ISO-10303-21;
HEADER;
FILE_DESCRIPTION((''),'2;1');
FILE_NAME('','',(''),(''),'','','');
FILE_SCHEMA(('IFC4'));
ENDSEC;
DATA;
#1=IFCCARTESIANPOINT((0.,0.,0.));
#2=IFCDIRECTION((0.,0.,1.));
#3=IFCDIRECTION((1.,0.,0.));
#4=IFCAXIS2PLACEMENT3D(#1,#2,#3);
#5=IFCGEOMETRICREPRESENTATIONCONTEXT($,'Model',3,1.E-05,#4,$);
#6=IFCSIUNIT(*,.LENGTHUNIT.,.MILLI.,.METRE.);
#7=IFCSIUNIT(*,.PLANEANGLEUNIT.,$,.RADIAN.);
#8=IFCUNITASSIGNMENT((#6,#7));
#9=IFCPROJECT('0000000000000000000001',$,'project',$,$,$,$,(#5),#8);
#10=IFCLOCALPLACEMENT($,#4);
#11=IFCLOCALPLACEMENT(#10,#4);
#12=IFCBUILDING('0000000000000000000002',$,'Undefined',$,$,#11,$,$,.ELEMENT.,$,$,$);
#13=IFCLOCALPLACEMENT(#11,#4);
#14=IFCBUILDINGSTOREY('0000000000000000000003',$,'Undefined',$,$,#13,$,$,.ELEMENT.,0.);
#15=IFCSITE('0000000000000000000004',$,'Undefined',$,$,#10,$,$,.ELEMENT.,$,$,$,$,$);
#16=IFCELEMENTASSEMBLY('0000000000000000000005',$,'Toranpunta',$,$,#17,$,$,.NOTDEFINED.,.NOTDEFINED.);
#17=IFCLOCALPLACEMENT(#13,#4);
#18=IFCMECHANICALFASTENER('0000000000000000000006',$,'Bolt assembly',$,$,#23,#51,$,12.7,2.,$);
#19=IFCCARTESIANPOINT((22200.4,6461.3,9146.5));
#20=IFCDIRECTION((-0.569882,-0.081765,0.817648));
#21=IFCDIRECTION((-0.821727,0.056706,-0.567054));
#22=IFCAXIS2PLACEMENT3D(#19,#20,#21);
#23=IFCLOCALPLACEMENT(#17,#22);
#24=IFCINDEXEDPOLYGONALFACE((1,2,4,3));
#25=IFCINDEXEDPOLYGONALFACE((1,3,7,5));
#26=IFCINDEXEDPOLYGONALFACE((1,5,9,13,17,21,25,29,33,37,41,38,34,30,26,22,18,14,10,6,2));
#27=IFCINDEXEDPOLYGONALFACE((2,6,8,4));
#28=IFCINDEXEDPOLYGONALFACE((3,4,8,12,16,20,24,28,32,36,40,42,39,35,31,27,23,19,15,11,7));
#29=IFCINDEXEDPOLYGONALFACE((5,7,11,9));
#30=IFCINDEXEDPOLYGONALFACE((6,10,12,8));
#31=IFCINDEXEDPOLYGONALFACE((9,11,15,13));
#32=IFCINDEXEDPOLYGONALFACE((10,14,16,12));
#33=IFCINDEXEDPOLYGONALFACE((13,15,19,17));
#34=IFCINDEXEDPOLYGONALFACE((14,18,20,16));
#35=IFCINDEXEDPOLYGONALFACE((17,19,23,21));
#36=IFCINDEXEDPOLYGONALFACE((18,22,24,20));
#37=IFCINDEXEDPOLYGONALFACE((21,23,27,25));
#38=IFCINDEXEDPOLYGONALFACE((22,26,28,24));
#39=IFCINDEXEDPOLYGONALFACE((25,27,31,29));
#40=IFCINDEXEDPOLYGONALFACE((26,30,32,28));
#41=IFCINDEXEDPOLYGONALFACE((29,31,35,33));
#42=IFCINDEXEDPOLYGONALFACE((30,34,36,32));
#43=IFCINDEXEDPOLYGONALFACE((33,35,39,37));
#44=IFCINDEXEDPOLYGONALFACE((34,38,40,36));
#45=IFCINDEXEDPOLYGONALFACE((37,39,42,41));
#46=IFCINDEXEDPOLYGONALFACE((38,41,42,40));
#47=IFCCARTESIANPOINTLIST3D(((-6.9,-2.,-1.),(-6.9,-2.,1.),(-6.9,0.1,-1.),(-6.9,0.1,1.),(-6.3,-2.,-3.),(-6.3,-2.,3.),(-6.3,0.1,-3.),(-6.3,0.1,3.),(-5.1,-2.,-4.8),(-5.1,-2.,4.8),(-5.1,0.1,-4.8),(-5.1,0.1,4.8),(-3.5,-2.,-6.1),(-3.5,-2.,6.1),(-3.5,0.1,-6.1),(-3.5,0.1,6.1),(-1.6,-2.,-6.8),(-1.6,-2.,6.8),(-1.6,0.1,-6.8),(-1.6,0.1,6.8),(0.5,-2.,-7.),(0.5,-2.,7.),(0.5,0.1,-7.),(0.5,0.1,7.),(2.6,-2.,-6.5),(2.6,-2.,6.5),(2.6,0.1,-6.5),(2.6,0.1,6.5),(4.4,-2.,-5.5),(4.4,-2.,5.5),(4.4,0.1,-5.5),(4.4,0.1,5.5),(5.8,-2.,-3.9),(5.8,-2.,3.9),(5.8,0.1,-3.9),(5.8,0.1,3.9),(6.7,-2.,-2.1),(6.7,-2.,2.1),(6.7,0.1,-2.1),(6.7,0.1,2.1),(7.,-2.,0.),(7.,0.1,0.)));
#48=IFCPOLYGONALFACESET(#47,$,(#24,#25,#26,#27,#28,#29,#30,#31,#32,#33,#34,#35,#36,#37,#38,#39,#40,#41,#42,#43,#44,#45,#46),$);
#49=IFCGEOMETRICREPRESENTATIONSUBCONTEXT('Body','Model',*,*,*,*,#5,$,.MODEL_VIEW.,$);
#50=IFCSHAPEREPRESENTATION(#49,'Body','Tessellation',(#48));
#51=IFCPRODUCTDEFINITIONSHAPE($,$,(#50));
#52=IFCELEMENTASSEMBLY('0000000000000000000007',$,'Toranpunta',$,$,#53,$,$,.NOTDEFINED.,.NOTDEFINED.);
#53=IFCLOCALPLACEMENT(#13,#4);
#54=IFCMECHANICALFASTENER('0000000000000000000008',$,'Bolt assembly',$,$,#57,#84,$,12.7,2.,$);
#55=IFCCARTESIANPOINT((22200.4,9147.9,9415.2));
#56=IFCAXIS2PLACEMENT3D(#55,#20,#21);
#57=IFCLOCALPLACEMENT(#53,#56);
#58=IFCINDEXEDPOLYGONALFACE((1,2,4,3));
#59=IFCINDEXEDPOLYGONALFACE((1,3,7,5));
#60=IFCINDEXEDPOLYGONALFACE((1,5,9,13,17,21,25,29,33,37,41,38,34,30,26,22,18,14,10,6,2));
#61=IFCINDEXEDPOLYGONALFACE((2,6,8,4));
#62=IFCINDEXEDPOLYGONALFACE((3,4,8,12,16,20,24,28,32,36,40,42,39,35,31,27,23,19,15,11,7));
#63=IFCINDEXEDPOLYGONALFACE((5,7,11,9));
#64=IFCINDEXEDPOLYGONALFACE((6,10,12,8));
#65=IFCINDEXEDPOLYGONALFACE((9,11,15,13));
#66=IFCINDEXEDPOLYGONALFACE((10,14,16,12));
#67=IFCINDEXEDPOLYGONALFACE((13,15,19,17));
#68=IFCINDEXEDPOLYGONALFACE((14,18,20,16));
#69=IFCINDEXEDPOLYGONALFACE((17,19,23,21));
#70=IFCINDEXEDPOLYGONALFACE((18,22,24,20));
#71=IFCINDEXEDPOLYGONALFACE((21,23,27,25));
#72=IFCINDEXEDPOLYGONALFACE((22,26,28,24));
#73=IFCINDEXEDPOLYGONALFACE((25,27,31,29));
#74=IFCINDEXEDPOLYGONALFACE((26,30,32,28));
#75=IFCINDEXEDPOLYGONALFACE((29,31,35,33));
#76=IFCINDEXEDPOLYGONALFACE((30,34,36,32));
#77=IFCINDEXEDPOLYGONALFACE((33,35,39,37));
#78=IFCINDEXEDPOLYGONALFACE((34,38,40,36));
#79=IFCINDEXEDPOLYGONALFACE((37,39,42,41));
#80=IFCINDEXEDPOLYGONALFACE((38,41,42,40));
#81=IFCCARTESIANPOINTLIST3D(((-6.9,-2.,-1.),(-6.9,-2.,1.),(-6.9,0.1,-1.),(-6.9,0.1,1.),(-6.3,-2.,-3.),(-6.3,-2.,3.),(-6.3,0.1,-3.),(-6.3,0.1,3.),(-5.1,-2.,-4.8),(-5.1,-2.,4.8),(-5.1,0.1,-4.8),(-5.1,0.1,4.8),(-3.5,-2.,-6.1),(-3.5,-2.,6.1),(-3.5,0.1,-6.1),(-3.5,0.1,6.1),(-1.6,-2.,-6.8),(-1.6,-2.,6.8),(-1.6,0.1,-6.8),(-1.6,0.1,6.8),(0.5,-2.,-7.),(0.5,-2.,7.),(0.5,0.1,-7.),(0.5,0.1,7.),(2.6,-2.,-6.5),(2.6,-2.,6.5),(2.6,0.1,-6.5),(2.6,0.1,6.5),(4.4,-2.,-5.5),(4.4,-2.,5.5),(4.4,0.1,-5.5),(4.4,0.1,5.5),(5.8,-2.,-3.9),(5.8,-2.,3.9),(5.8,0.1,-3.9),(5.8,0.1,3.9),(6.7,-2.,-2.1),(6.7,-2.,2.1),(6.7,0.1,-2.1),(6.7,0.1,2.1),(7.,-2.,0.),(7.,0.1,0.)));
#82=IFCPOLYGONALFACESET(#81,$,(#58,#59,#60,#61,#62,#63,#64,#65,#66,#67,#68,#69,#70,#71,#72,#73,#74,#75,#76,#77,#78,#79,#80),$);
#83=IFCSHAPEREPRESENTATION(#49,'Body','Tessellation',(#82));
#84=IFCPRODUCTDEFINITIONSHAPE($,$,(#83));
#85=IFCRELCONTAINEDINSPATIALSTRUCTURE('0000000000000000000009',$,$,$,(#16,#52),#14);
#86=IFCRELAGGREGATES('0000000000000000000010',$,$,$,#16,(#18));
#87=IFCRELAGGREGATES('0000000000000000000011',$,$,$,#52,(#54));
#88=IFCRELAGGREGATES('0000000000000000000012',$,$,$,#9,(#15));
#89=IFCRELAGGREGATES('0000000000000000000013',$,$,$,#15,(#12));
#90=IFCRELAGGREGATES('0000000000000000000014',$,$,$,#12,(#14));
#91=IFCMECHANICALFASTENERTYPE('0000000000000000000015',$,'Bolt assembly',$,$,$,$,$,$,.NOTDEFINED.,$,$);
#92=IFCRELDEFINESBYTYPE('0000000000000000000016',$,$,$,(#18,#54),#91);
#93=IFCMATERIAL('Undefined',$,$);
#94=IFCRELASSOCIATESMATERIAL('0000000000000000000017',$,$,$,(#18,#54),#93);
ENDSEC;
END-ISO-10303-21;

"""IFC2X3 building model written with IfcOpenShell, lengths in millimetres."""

from ifc_helpers import new_model, si_unit, frame, origin_with_axes, origin_2d_with_axis, place, context, subcontext, project, spatial, circle, extrude, source, transform, mapped, material, type_object, element, aggregate, save


model = new_model("IFC2X3")

# Units and contexts
model_context = context("Model", 3, precision=1e-05, world=origin_with_axes())
body_context = subcontext(model_context, "Body", "Model", "MODEL_VIEW")
ifc_project = project(units=[si_unit("LENGTHUNIT", "METRE", prefix="MILLI"), si_unit("PLANEANGLEUNIT", "RADIAN")], contexts=[model_context])

# Site, building, storey
site_placement = place(None, origin_with_axes())
site = spatial("IfcSite", under=ifc_project, at=site_placement, Name="Undefined", CompositionType="ELEMENT")
building_placement = place(site_placement, origin_with_axes())
building = spatial("IfcBuilding", under=site, at=building_placement, Name="Undefined", CompositionType="ELEMENT")
storey_placement = place(building_placement, origin_with_axes())
storey = spatial("IfcBuildingStorey", under=building, at=storey_placement, Name="Undefined", CompositionType="ELEMENT", Elevation=0.0)

# Shared definitions
ifc_material_1 = material(Name="Undefined")
mechanical_fastener_type = type_object("IfcMechanicalFastenerType", Name="Bolt assembly")

# Element assemblies, mechanical fasteners
assembly_1_placement = place(storey_placement, origin_with_axes())
assembly_1 = element("IfcElementAssembly", 1, at=assembly_1_placement, inside=storey, Name="Toranpunta", AssemblyPlace="NOTDEFINED", PredefinedType="NOTDEFINED")
shared_shape_1 = source(origin_with_axes(), body_context, "Body", "SweptSolid", [
    extrude(circle(Radius=7.0, at=origin_2d_with_axis()), frame((0.0, -2.0, 0.0), z_axis=(0.0, 1.0, 0.0), x_axis=(1.0, 0.0, 0.0)), (0.0, 0.0, 1.0), 2.1),
])
mechanical_fastener_1_placement = place(assembly_1_placement, frame((22200.4, 6461.3, 9146.5), z_axis=(-0.569882, -0.081765, 0.817648), x_axis=(-0.821727, 0.056706, -0.567054)))
mechanical_fastener_1 = element("IfcMechanicalFastener", 2, at=mechanical_fastener_1_placement, type_object=mechanical_fastener_type, material=ifc_material_1, Name="Bolt assembly", NominalDiameter=12.7, NominalLength=2.0, context=body_context, shape_type="MappedRepresentation", body=[
    mapped(shared_shape_1, transform((0.0, 0.0, 0.0))),
])
aggregate(assembly_1, [mechanical_fastener_1])
assembly_2_placement = place(storey_placement, origin_with_axes())
assembly_2 = element("IfcElementAssembly", 3, at=assembly_2_placement, inside=storey, Name="Toranpunta", AssemblyPlace="NOTDEFINED", PredefinedType="NOTDEFINED")
mechanical_fastener_2_placement = place(assembly_2_placement, frame((22200.4, 9147.9, 9415.2), z_axis=(-0.569882, -0.081765, 0.817648), x_axis=(-0.821727, 0.056706, -0.567054)))
mechanical_fastener_2 = element("IfcMechanicalFastener", 4, at=mechanical_fastener_2_placement, type_object=mechanical_fastener_type, material=ifc_material_1, Name="Bolt assembly", NominalDiameter=12.7, NominalLength=2.0, context=body_context, shape_type="MappedRepresentation", body=[
    mapped(shared_shape_1, transform((0.0, 0.0, 0.0))),
])
aggregate(assembly_2, [mechanical_fastener_2])

save(model, "model.ifc")
